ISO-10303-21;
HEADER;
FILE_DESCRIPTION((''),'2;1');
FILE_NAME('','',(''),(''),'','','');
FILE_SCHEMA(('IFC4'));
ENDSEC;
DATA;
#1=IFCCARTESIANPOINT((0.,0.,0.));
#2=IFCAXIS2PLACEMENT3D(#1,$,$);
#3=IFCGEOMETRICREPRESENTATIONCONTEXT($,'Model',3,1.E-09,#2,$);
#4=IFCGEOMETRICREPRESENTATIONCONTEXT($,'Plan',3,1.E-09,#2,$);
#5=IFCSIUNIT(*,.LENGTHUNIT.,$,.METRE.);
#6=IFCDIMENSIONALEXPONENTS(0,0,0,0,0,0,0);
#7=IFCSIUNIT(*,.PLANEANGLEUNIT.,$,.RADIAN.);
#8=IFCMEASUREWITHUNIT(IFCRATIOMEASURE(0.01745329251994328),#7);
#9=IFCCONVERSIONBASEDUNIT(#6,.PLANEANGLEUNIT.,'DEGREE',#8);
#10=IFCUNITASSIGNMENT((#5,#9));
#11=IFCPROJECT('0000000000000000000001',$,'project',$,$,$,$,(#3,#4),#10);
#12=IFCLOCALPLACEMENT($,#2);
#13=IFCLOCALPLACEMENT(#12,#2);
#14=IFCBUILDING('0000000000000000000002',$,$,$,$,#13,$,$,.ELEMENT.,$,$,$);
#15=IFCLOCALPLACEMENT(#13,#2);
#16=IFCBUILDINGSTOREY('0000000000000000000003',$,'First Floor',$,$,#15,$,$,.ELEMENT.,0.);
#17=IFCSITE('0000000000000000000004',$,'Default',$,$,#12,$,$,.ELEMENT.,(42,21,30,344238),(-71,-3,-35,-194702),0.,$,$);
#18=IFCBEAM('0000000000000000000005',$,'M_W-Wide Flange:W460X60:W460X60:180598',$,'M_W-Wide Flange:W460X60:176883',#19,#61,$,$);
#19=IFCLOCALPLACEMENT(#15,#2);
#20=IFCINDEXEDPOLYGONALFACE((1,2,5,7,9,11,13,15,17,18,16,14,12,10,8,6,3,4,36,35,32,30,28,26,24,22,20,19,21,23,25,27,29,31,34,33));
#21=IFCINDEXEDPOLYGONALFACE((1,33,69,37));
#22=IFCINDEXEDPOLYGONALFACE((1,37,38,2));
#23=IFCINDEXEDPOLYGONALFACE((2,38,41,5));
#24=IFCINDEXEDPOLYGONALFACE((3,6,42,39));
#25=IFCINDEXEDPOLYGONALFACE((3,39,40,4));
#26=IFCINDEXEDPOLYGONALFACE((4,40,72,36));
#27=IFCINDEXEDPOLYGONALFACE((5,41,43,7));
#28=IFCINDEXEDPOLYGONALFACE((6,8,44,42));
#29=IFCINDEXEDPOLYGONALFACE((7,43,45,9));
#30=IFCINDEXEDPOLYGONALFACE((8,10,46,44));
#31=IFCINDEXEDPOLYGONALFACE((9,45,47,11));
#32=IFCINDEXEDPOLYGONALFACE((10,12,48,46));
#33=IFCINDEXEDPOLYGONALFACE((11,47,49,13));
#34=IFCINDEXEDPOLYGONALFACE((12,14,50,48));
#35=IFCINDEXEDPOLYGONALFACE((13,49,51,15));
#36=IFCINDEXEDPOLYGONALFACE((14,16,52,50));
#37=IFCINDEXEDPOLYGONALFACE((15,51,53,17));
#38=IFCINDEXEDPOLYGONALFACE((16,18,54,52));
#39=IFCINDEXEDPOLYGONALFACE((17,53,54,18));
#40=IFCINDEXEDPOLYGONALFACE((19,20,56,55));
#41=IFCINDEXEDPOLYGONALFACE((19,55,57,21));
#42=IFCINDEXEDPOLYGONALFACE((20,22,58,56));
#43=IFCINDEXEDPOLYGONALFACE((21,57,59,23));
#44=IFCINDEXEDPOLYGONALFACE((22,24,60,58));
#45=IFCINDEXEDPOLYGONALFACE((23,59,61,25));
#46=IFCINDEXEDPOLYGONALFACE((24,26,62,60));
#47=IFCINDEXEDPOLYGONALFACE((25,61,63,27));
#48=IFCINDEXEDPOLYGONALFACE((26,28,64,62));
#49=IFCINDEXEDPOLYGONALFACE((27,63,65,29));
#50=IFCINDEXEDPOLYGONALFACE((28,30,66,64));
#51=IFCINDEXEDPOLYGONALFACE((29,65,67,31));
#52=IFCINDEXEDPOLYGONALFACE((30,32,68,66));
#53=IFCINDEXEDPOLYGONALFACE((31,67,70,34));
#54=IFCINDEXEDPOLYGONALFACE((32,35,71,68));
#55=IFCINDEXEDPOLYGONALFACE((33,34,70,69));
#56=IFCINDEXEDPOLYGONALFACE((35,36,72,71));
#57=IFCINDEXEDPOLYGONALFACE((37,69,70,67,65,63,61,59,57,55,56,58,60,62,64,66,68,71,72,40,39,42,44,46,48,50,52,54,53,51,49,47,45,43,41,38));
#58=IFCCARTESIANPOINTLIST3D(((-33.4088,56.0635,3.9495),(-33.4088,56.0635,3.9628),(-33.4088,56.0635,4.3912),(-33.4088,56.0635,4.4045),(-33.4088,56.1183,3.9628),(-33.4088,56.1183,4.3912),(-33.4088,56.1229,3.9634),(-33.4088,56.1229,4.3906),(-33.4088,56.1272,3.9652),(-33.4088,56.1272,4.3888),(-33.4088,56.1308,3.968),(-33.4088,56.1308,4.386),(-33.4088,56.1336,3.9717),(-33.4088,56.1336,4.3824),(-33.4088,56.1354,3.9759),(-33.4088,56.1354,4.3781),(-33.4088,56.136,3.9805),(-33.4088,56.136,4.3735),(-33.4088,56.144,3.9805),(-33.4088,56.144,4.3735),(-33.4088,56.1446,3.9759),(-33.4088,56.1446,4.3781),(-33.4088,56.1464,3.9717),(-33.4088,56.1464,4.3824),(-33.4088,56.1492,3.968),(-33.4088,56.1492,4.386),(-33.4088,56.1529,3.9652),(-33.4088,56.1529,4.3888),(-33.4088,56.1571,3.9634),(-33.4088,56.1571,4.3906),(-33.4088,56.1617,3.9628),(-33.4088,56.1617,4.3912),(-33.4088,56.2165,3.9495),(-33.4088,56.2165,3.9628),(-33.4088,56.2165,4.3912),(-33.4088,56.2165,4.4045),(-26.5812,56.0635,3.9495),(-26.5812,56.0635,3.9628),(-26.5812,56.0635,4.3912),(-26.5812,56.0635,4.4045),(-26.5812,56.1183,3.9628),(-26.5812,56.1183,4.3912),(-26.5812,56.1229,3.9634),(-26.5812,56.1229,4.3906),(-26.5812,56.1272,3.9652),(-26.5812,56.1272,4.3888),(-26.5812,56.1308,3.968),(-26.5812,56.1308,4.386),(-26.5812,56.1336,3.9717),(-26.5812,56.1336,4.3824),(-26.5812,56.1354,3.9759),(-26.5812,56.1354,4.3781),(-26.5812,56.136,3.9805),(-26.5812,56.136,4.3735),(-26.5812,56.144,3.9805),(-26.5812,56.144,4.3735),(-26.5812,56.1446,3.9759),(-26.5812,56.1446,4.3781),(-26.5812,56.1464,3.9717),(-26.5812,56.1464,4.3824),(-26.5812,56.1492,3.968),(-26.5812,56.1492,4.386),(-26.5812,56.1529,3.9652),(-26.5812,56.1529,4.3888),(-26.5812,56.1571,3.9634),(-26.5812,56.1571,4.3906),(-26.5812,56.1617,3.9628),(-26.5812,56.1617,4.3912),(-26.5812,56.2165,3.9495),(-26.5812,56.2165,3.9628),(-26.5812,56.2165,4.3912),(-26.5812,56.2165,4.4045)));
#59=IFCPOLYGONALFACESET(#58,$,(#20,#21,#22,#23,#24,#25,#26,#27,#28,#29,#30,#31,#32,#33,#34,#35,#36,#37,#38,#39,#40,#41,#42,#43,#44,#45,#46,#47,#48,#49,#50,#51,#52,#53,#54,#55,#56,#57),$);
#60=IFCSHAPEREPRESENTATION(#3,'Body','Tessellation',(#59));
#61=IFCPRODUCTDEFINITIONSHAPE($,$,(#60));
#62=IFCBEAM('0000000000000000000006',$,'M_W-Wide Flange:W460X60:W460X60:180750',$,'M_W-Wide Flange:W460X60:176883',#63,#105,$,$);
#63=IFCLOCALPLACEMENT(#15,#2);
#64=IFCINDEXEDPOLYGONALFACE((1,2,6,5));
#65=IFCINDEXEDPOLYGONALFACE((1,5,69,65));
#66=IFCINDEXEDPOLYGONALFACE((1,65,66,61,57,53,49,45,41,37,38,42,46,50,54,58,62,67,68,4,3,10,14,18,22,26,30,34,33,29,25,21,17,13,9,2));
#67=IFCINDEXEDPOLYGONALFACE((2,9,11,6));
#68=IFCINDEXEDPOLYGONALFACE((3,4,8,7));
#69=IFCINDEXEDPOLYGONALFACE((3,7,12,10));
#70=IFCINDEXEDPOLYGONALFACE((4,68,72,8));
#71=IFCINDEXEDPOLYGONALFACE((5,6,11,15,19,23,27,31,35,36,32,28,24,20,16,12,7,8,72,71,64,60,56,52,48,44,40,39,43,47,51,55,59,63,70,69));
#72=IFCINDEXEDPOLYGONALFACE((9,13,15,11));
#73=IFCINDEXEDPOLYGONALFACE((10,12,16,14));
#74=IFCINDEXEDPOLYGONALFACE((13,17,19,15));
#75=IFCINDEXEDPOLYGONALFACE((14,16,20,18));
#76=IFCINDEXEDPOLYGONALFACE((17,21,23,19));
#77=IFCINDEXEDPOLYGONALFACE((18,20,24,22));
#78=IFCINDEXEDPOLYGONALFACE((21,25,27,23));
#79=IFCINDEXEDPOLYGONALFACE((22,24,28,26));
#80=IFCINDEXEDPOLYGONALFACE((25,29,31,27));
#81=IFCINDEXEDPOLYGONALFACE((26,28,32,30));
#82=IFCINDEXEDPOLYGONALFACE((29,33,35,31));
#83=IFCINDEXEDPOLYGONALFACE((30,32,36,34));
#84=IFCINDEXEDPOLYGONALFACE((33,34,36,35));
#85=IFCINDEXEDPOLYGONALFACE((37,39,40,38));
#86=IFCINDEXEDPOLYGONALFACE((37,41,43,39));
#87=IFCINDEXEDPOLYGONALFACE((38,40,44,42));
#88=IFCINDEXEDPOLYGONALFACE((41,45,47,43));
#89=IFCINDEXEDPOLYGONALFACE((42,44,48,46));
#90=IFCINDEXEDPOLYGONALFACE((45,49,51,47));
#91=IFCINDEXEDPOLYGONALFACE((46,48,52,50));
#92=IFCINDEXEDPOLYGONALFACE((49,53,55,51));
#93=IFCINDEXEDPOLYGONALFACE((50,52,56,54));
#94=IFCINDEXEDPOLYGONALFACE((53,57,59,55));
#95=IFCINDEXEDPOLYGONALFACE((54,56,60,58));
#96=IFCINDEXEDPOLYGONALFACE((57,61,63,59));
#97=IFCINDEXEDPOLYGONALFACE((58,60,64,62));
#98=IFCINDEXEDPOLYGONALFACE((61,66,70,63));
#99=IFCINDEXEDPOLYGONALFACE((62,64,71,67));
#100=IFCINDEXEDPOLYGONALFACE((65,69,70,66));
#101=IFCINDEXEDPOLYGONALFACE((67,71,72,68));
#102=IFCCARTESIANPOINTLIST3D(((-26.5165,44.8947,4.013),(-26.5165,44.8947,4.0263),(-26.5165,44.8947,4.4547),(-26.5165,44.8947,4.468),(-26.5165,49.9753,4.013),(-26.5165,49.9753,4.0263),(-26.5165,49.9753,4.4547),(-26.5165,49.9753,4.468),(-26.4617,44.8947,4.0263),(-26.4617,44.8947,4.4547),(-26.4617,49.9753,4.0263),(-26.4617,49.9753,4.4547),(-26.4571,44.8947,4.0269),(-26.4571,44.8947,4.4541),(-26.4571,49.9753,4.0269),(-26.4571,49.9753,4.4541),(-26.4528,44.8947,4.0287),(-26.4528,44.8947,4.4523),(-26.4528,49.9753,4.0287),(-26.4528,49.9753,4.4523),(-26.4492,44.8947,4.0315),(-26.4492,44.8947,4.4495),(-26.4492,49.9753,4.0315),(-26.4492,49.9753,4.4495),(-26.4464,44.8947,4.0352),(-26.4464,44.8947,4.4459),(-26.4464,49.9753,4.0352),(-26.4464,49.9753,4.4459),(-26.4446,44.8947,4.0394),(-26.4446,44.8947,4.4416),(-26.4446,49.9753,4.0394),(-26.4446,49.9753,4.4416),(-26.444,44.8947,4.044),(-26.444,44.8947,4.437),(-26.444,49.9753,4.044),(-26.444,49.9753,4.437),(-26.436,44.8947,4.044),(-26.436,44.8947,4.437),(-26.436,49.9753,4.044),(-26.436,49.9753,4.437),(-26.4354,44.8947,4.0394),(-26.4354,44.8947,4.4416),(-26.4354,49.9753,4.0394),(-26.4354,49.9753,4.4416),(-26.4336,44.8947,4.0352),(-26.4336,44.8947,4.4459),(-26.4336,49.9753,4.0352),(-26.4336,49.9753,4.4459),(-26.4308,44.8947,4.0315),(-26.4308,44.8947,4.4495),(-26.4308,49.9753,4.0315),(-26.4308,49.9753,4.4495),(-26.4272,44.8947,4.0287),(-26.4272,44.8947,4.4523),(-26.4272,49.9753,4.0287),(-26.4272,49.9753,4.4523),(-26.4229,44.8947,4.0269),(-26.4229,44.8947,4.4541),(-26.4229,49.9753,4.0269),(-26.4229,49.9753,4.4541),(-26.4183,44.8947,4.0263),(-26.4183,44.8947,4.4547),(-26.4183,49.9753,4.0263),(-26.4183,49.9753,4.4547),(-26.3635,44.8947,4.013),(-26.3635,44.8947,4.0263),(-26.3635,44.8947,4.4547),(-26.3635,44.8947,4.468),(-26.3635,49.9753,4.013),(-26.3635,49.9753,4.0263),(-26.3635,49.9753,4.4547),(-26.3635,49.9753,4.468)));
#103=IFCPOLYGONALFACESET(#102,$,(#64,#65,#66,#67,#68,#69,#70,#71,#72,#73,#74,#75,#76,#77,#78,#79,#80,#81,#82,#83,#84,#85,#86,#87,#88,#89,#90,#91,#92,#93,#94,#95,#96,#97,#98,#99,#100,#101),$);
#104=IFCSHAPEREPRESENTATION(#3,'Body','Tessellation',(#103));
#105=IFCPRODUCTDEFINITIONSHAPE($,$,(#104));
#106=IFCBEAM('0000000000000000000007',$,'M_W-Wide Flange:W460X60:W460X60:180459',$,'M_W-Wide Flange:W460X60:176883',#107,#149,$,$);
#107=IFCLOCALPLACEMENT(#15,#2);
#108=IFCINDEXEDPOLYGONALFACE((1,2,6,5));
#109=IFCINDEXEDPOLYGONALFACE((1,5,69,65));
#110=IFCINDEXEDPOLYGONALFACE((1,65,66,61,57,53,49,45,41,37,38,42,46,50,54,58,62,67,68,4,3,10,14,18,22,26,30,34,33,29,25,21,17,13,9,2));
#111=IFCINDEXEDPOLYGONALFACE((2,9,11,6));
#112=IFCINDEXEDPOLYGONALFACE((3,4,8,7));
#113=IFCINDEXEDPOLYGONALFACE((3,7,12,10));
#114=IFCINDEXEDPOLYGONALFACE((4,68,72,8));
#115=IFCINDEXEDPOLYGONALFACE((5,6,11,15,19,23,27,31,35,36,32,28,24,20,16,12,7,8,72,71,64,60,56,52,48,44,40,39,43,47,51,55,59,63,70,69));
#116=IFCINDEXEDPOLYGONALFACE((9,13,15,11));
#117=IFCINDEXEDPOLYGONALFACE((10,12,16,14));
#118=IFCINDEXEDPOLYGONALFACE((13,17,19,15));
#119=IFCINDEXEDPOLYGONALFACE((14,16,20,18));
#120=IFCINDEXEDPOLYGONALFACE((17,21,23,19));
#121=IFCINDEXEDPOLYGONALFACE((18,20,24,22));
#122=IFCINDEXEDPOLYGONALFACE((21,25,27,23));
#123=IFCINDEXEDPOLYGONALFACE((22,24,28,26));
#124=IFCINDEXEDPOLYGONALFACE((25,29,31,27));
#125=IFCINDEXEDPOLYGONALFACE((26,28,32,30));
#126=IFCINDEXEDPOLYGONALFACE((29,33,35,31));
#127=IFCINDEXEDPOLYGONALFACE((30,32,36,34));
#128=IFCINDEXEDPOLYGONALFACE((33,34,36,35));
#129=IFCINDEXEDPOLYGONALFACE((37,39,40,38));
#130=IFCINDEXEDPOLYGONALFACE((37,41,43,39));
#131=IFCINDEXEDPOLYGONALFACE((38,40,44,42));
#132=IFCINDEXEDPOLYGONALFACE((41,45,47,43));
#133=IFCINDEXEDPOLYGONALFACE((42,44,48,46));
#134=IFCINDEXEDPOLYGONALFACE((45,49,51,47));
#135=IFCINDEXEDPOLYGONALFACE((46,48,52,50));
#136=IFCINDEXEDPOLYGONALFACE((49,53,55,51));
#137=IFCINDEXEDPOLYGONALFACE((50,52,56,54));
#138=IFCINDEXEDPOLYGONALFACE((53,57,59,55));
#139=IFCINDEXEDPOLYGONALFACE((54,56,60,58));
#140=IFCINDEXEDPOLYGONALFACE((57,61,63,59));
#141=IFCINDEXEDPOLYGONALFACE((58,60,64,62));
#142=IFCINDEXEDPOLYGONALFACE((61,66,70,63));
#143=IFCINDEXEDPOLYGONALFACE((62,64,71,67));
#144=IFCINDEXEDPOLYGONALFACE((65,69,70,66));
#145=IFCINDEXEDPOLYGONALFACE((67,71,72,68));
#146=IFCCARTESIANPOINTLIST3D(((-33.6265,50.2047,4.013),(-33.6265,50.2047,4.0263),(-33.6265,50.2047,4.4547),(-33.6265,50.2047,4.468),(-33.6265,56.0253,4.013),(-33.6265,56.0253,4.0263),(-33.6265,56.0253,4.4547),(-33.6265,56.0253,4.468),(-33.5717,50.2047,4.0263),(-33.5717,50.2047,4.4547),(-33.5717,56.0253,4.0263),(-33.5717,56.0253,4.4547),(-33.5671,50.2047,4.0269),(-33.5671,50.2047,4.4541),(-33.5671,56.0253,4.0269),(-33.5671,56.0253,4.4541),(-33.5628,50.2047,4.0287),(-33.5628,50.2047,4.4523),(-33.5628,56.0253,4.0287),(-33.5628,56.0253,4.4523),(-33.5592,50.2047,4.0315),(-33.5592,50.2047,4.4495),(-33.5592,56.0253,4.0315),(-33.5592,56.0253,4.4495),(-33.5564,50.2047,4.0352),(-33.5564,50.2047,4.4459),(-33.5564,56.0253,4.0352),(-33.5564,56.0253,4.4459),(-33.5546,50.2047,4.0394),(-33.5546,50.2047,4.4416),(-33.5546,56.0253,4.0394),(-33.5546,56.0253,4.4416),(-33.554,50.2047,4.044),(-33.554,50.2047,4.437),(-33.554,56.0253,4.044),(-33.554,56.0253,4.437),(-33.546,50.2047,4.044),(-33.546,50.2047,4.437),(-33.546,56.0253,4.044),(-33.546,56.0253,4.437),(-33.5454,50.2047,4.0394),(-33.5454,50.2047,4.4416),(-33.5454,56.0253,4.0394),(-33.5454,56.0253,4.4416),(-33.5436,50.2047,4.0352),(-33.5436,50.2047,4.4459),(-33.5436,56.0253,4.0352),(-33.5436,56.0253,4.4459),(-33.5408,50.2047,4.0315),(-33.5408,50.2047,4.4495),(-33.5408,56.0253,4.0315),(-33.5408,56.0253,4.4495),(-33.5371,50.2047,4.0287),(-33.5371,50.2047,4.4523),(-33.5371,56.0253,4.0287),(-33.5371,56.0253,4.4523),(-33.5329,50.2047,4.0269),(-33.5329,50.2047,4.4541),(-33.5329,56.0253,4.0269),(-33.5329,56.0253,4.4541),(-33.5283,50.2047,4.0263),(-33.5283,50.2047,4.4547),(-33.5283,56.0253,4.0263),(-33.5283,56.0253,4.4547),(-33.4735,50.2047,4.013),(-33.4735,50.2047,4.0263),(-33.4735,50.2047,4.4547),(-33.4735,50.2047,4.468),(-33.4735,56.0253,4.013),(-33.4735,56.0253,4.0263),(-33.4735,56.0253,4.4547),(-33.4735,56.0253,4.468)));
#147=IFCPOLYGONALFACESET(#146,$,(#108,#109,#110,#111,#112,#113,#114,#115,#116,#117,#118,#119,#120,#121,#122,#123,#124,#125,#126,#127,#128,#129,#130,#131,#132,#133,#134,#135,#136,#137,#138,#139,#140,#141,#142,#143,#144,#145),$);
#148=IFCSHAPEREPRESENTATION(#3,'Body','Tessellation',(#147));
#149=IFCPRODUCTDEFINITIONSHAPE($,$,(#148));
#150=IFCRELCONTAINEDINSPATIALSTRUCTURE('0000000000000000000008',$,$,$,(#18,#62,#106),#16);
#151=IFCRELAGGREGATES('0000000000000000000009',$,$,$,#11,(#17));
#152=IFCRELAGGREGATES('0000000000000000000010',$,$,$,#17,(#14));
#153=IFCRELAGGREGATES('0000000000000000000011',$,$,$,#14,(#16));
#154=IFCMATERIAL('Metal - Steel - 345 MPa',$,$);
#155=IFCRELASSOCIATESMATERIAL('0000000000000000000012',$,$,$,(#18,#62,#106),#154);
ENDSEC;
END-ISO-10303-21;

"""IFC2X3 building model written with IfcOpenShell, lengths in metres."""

from ifc_helpers import new_model, entity, si_unit, converted_unit, frame, frame_2d, origin, place, context, project, spatial, polyline, circle_curve, parameter, trimmed, segment, composite_curve, outline, extrude, material, element, save


model = new_model("IFC2X3")

# Units and contexts
model_context = context("Model", 3, precision=1e-09, world=origin())
plan_context = context("Plan", 3, precision=1e-09, world=origin())
ifc_project = project(units=[si_unit("LENGTHUNIT", "METRE"), converted_unit("PLANEANGLEUNIT", "DEGREE", entity("IfcRatioMeasure", 0.01745329251994328), si_unit("PLANEANGLEUNIT", "RADIAN"), dimensions=[0, 0, 0, 0, 0, 0, 0])], contexts=[model_context, plan_context])

# Site, building, storey
site_placement = place(None, origin())
site = spatial("IfcSite", under=ifc_project, at=site_placement, Name="Default", CompositionType="ELEMENT", RefLatitude=(42, 21, 30, 344238), RefLongitude=(-71, -3, -35, -194702), RefElevation=0.0)
building_placement = place(site_placement, origin())
building = spatial("IfcBuilding", under=site, at=building_placement, CompositionType="ELEMENT")
storey_placement = place(building_placement, origin())
storey = spatial("IfcBuildingStorey", under=building, at=storey_placement, Name="First Floor", CompositionType="ELEMENT", Elevation=0.0)

# Beams
ifc_material = material(Name="Metal - Steel - 345 MPa")
beam_1_placement = place(storey_placement, frame((-33.5519, 56.14, 4.4045), z_axis=(0.0, 0.0, 1.0), x_axis=(0.0, -1.0, 0.0)))
element("IfcBeam", 1, at=beam_1_placement, inside=storey, material=ifc_material, Name="M_W-Wide Flange:W460X60:W460X60:180598", ObjectType="M_W-Wide Flange:W460X60:176883", context=model_context, shape_type="SweptSolid", body=[
    extrude(outline(composite_curve([segment(polyline([(-0.0765, -0.2142), (-0.0765, -0.2275)]), True, "CONTINUOUS"), segment(polyline([(-0.0765, -0.2275), (0.0765, -0.2275)]), True, "CONTINUOUS"), segment(polyline([(0.0765, -0.2275), (0.0765, -0.2142)]), True, "CONTINUOUS"), segment(polyline([(0.0765, -0.2142), (0.0217, -0.2142)]), True, "CONTINUOUS"), segment(trimmed(circle_curve(frame_2d((0.0217, -0.1965), x_axis=(0.0, -1.0)), 0.0177), [parameter(270.0)], [parameter(360.0)], True, "PARAMETER"), False, "CONTINUOUS"), segment(polyline([(0.004, -0.1965), (0.004, 0.1965)]), True, "CONTINUOUS"), segment(trimmed(circle_curve(frame_2d((0.0217, 0.1965), x_axis=(-1.0, 0.0)), 0.0177), [parameter(270.0)], [parameter(360.0)], True, "PARAMETER"), False, "CONTINUOUS"), segment(polyline([(0.0217, 0.2142), (0.0765, 0.2142)]), True, "CONTINUOUS"), segment(polyline([(0.0765, 0.2142), (0.0765, 0.2275)]), True, "CONTINUOUS"), segment(polyline([(0.0765, 0.2275), (-0.0765, 0.2275)]), True, "CONTINUOUS"), segment(polyline([(-0.0765, 0.2275), (-0.0765, 0.2142)]), True, "CONTINUOUS"), segment(polyline([(-0.0765, 0.2142), (-0.0217, 0.2142)]), True, "CONTINUOUS"), segment(trimmed(circle_curve(frame_2d((-0.0217, 0.1965), x_axis=(0.0, 1.0)), 0.0177), [parameter(270.0)], [parameter(360.0)], True, "PARAMETER"), False, "CONTINUOUS"), segment(polyline([(-0.004, 0.1965), (-0.004, -0.1965)]), True, "CONTINUOUS"), segment(trimmed(circle_curve(frame_2d((-0.0217, -0.1965), x_axis=(1.0, 0.0)), 0.0177), [parameter(270.0)], [parameter(0.0)], True, "PARAMETER"), False, "CONTINUOUS"), segment(polyline([(-0.0217, -0.2142), (-0.0765, -0.2142)]), True, "CONTINUOUS")], self_intersect=False)), frame((0.0, 0.1431, -0.2275), z_axis=(0.0, -1.0, 0.0), x_axis=(1.0, 0.0, 0.0)), (0.0, 0.0, -1.0), 6.8276),
])
beam_2_placement = place(storey_placement, frame((-26.44, 50.0926, 4.468), z_axis=(0.0, 0.0, 1.0), x_axis=(-1.0, 0.0, 0.0)))
element("IfcBeam", 2, at=beam_2_placement, inside=storey, material=ifc_material, Name="M_W-Wide Flange:W460X60:W460X60:180750", ObjectType="M_W-Wide Flange:W460X60:176883", context=model_context, shape_type="SweptSolid", body=[
    extrude(outline(composite_curve([segment(polyline([(0.2142, -0.0765), (0.2275, -0.0765)]), True, "CONTINUOUS"), segment(polyline([(0.2275, -0.0765), (0.2275, 0.0765)]), True, "CONTINUOUS"), segment(polyline([(0.2275, 0.0765), (0.2142, 0.0765)]), True, "CONTINUOUS"), segment(polyline([(0.2142, 0.0765), (0.2142, 0.0217)]), True, "CONTINUOUS"), segment(trimmed(circle_curve(frame_2d((0.1965, 0.0217), x_axis=(1.0, 0.0)), 0.0177), [parameter(270.0)], [parameter(360.0)], True, "PARAMETER"), False, "CONTINUOUS"), segment(polyline([(0.1965, 0.004), (-0.1965, 0.004)]), True, "CONTINUOUS"), segment(trimmed(circle_curve(frame_2d((-0.1965, 0.0217), x_axis=(0.0, -1.0)), 0.0177), [parameter(270.0)], [parameter(360.0)], True, "PARAMETER"), False, "CONTINUOUS"), segment(polyline([(-0.2142, 0.0217), (-0.2142, 0.0765)]), True, "CONTINUOUS"), segment(polyline([(-0.2142, 0.0765), (-0.2275, 0.0765)]), True, "CONTINUOUS"), segment(polyline([(-0.2275, 0.0765), (-0.2275, -0.0765)]), True, "CONTINUOUS"), segment(polyline([(-0.2275, -0.0765), (-0.2142, -0.0765)]), True, "CONTINUOUS"), segment(polyline([(-0.2142, -0.0765), (-0.2142, -0.0217)]), True, "CONTINUOUS"), segment(trimmed(circle_curve(frame_2d((-0.1965, -0.0217), x_axis=(-1.0, 0.0)), 0.0177), [parameter(270.0)], [parameter(360.0)], True, "PARAMETER"), False, "CONTINUOUS"), segment(polyline([(-0.1965, -0.004), (0.1965, -0.004)]), True, "CONTINUOUS"), segment(trimmed(circle_curve(frame_2d((0.1965, -0.0217), x_axis=(0.0, 1.0)), 0.0177), [parameter(270.0)], [parameter(0.0)], True, "PARAMETER"), False, "CONTINUOUS"), segment(polyline([(0.2142, -0.0217), (0.2142, -0.0765)]), True, "CONTINUOUS")], self_intersect=False)), frame((0.0, 5.1979, -0.2275), z_axis=(0.0, -1.0, 0.0), x_axis=(0.0, 0.0, -1.0)), (0.0, 0.0, 1.0), 5.0806),
])
beam_3_placement = place(storey_placement, frame((-33.55, 56.1423, 4.468), z_axis=(0.0, 0.0, 1.0), x_axis=(-1.0, 0.0, 0.0)))
element("IfcBeam", 3, at=beam_3_placement, inside=storey, material=ifc_material, Name="M_W-Wide Flange:W460X60:W460X60:180459", ObjectType="M_W-Wide Flange:W460X60:176883", context=model_context, shape_type="SweptSolid", body=[
    extrude(outline(composite_curve([segment(polyline([(0.2142, -0.0765), (0.2275, -0.0765)]), True, "CONTINUOUS"), segment(polyline([(0.2275, -0.0765), (0.2275, 0.0765)]), True, "CONTINUOUS"), segment(polyline([(0.2275, 0.0765), (0.2142, 0.0765)]), True, "CONTINUOUS"), segment(polyline([(0.2142, 0.0765), (0.2142, 0.0217)]), True, "CONTINUOUS"), segment(trimmed(circle_curve(frame_2d((0.1965, 0.0217), x_axis=(0.0, 1.0)), 0.0177), [parameter(180.0)], [parameter(270.0)], True, "PARAMETER"), False, "CONTINUOUS"), segment(polyline([(0.1965, 0.004), (-0.1965, 0.004)]), True, "CONTINUOUS"), segment(trimmed(circle_curve(frame_2d((-0.1965, 0.0217), x_axis=(0.0, 1.0)), 0.0177), [parameter(90.0)], [parameter(180.0)], True, "PARAMETER"), False, "CONTINUOUS"), segment(polyline([(-0.2142, 0.0217), (-0.2142, 0.0765)]), True, "CONTINUOUS"), segment(polyline([(-0.2142, 0.0765), (-0.2275, 0.0765)]), True, "CONTINUOUS"), segment(polyline([(-0.2275, 0.0765), (-0.2275, -0.0765)]), True, "CONTINUOUS"), segment(polyline([(-0.2275, -0.0765), (-0.2142, -0.0765)]), True, "CONTINUOUS"), segment(polyline([(-0.2142, -0.0765), (-0.2142, -0.0217)]), True, "CONTINUOUS"), segment(trimmed(circle_curve(frame_2d((-0.1965, -0.0217), x_axis=(0.0, 1.0)), 0.0177), [parameter(360.0)], [parameter(90.0)], True, "PARAMETER"), False, "CONTINUOUS"), segment(polyline([(-0.1965, -0.004), (0.1965, -0.004)]), True, "CONTINUOUS"), segment(trimmed(circle_curve(frame_2d((0.1965, -0.0217), x_axis=(0.0, 1.0)), 0.0177), [parameter(270.0)], [parameter(0.0)], True, "PARAMETER"), False, "CONTINUOUS"), segment(polyline([(0.2142, -0.0217), (0.2142, -0.0765)]), True, "CONTINUOUS")], self_intersect=False)), frame((0.0, 5.9376, -0.2275), z_axis=(0.0, -1.0, 0.0), x_axis=(0.0, 0.0, -1.0)), (0.0, 0.0, 1.0), 5.8206),
])

save(model, "model.ifc")
